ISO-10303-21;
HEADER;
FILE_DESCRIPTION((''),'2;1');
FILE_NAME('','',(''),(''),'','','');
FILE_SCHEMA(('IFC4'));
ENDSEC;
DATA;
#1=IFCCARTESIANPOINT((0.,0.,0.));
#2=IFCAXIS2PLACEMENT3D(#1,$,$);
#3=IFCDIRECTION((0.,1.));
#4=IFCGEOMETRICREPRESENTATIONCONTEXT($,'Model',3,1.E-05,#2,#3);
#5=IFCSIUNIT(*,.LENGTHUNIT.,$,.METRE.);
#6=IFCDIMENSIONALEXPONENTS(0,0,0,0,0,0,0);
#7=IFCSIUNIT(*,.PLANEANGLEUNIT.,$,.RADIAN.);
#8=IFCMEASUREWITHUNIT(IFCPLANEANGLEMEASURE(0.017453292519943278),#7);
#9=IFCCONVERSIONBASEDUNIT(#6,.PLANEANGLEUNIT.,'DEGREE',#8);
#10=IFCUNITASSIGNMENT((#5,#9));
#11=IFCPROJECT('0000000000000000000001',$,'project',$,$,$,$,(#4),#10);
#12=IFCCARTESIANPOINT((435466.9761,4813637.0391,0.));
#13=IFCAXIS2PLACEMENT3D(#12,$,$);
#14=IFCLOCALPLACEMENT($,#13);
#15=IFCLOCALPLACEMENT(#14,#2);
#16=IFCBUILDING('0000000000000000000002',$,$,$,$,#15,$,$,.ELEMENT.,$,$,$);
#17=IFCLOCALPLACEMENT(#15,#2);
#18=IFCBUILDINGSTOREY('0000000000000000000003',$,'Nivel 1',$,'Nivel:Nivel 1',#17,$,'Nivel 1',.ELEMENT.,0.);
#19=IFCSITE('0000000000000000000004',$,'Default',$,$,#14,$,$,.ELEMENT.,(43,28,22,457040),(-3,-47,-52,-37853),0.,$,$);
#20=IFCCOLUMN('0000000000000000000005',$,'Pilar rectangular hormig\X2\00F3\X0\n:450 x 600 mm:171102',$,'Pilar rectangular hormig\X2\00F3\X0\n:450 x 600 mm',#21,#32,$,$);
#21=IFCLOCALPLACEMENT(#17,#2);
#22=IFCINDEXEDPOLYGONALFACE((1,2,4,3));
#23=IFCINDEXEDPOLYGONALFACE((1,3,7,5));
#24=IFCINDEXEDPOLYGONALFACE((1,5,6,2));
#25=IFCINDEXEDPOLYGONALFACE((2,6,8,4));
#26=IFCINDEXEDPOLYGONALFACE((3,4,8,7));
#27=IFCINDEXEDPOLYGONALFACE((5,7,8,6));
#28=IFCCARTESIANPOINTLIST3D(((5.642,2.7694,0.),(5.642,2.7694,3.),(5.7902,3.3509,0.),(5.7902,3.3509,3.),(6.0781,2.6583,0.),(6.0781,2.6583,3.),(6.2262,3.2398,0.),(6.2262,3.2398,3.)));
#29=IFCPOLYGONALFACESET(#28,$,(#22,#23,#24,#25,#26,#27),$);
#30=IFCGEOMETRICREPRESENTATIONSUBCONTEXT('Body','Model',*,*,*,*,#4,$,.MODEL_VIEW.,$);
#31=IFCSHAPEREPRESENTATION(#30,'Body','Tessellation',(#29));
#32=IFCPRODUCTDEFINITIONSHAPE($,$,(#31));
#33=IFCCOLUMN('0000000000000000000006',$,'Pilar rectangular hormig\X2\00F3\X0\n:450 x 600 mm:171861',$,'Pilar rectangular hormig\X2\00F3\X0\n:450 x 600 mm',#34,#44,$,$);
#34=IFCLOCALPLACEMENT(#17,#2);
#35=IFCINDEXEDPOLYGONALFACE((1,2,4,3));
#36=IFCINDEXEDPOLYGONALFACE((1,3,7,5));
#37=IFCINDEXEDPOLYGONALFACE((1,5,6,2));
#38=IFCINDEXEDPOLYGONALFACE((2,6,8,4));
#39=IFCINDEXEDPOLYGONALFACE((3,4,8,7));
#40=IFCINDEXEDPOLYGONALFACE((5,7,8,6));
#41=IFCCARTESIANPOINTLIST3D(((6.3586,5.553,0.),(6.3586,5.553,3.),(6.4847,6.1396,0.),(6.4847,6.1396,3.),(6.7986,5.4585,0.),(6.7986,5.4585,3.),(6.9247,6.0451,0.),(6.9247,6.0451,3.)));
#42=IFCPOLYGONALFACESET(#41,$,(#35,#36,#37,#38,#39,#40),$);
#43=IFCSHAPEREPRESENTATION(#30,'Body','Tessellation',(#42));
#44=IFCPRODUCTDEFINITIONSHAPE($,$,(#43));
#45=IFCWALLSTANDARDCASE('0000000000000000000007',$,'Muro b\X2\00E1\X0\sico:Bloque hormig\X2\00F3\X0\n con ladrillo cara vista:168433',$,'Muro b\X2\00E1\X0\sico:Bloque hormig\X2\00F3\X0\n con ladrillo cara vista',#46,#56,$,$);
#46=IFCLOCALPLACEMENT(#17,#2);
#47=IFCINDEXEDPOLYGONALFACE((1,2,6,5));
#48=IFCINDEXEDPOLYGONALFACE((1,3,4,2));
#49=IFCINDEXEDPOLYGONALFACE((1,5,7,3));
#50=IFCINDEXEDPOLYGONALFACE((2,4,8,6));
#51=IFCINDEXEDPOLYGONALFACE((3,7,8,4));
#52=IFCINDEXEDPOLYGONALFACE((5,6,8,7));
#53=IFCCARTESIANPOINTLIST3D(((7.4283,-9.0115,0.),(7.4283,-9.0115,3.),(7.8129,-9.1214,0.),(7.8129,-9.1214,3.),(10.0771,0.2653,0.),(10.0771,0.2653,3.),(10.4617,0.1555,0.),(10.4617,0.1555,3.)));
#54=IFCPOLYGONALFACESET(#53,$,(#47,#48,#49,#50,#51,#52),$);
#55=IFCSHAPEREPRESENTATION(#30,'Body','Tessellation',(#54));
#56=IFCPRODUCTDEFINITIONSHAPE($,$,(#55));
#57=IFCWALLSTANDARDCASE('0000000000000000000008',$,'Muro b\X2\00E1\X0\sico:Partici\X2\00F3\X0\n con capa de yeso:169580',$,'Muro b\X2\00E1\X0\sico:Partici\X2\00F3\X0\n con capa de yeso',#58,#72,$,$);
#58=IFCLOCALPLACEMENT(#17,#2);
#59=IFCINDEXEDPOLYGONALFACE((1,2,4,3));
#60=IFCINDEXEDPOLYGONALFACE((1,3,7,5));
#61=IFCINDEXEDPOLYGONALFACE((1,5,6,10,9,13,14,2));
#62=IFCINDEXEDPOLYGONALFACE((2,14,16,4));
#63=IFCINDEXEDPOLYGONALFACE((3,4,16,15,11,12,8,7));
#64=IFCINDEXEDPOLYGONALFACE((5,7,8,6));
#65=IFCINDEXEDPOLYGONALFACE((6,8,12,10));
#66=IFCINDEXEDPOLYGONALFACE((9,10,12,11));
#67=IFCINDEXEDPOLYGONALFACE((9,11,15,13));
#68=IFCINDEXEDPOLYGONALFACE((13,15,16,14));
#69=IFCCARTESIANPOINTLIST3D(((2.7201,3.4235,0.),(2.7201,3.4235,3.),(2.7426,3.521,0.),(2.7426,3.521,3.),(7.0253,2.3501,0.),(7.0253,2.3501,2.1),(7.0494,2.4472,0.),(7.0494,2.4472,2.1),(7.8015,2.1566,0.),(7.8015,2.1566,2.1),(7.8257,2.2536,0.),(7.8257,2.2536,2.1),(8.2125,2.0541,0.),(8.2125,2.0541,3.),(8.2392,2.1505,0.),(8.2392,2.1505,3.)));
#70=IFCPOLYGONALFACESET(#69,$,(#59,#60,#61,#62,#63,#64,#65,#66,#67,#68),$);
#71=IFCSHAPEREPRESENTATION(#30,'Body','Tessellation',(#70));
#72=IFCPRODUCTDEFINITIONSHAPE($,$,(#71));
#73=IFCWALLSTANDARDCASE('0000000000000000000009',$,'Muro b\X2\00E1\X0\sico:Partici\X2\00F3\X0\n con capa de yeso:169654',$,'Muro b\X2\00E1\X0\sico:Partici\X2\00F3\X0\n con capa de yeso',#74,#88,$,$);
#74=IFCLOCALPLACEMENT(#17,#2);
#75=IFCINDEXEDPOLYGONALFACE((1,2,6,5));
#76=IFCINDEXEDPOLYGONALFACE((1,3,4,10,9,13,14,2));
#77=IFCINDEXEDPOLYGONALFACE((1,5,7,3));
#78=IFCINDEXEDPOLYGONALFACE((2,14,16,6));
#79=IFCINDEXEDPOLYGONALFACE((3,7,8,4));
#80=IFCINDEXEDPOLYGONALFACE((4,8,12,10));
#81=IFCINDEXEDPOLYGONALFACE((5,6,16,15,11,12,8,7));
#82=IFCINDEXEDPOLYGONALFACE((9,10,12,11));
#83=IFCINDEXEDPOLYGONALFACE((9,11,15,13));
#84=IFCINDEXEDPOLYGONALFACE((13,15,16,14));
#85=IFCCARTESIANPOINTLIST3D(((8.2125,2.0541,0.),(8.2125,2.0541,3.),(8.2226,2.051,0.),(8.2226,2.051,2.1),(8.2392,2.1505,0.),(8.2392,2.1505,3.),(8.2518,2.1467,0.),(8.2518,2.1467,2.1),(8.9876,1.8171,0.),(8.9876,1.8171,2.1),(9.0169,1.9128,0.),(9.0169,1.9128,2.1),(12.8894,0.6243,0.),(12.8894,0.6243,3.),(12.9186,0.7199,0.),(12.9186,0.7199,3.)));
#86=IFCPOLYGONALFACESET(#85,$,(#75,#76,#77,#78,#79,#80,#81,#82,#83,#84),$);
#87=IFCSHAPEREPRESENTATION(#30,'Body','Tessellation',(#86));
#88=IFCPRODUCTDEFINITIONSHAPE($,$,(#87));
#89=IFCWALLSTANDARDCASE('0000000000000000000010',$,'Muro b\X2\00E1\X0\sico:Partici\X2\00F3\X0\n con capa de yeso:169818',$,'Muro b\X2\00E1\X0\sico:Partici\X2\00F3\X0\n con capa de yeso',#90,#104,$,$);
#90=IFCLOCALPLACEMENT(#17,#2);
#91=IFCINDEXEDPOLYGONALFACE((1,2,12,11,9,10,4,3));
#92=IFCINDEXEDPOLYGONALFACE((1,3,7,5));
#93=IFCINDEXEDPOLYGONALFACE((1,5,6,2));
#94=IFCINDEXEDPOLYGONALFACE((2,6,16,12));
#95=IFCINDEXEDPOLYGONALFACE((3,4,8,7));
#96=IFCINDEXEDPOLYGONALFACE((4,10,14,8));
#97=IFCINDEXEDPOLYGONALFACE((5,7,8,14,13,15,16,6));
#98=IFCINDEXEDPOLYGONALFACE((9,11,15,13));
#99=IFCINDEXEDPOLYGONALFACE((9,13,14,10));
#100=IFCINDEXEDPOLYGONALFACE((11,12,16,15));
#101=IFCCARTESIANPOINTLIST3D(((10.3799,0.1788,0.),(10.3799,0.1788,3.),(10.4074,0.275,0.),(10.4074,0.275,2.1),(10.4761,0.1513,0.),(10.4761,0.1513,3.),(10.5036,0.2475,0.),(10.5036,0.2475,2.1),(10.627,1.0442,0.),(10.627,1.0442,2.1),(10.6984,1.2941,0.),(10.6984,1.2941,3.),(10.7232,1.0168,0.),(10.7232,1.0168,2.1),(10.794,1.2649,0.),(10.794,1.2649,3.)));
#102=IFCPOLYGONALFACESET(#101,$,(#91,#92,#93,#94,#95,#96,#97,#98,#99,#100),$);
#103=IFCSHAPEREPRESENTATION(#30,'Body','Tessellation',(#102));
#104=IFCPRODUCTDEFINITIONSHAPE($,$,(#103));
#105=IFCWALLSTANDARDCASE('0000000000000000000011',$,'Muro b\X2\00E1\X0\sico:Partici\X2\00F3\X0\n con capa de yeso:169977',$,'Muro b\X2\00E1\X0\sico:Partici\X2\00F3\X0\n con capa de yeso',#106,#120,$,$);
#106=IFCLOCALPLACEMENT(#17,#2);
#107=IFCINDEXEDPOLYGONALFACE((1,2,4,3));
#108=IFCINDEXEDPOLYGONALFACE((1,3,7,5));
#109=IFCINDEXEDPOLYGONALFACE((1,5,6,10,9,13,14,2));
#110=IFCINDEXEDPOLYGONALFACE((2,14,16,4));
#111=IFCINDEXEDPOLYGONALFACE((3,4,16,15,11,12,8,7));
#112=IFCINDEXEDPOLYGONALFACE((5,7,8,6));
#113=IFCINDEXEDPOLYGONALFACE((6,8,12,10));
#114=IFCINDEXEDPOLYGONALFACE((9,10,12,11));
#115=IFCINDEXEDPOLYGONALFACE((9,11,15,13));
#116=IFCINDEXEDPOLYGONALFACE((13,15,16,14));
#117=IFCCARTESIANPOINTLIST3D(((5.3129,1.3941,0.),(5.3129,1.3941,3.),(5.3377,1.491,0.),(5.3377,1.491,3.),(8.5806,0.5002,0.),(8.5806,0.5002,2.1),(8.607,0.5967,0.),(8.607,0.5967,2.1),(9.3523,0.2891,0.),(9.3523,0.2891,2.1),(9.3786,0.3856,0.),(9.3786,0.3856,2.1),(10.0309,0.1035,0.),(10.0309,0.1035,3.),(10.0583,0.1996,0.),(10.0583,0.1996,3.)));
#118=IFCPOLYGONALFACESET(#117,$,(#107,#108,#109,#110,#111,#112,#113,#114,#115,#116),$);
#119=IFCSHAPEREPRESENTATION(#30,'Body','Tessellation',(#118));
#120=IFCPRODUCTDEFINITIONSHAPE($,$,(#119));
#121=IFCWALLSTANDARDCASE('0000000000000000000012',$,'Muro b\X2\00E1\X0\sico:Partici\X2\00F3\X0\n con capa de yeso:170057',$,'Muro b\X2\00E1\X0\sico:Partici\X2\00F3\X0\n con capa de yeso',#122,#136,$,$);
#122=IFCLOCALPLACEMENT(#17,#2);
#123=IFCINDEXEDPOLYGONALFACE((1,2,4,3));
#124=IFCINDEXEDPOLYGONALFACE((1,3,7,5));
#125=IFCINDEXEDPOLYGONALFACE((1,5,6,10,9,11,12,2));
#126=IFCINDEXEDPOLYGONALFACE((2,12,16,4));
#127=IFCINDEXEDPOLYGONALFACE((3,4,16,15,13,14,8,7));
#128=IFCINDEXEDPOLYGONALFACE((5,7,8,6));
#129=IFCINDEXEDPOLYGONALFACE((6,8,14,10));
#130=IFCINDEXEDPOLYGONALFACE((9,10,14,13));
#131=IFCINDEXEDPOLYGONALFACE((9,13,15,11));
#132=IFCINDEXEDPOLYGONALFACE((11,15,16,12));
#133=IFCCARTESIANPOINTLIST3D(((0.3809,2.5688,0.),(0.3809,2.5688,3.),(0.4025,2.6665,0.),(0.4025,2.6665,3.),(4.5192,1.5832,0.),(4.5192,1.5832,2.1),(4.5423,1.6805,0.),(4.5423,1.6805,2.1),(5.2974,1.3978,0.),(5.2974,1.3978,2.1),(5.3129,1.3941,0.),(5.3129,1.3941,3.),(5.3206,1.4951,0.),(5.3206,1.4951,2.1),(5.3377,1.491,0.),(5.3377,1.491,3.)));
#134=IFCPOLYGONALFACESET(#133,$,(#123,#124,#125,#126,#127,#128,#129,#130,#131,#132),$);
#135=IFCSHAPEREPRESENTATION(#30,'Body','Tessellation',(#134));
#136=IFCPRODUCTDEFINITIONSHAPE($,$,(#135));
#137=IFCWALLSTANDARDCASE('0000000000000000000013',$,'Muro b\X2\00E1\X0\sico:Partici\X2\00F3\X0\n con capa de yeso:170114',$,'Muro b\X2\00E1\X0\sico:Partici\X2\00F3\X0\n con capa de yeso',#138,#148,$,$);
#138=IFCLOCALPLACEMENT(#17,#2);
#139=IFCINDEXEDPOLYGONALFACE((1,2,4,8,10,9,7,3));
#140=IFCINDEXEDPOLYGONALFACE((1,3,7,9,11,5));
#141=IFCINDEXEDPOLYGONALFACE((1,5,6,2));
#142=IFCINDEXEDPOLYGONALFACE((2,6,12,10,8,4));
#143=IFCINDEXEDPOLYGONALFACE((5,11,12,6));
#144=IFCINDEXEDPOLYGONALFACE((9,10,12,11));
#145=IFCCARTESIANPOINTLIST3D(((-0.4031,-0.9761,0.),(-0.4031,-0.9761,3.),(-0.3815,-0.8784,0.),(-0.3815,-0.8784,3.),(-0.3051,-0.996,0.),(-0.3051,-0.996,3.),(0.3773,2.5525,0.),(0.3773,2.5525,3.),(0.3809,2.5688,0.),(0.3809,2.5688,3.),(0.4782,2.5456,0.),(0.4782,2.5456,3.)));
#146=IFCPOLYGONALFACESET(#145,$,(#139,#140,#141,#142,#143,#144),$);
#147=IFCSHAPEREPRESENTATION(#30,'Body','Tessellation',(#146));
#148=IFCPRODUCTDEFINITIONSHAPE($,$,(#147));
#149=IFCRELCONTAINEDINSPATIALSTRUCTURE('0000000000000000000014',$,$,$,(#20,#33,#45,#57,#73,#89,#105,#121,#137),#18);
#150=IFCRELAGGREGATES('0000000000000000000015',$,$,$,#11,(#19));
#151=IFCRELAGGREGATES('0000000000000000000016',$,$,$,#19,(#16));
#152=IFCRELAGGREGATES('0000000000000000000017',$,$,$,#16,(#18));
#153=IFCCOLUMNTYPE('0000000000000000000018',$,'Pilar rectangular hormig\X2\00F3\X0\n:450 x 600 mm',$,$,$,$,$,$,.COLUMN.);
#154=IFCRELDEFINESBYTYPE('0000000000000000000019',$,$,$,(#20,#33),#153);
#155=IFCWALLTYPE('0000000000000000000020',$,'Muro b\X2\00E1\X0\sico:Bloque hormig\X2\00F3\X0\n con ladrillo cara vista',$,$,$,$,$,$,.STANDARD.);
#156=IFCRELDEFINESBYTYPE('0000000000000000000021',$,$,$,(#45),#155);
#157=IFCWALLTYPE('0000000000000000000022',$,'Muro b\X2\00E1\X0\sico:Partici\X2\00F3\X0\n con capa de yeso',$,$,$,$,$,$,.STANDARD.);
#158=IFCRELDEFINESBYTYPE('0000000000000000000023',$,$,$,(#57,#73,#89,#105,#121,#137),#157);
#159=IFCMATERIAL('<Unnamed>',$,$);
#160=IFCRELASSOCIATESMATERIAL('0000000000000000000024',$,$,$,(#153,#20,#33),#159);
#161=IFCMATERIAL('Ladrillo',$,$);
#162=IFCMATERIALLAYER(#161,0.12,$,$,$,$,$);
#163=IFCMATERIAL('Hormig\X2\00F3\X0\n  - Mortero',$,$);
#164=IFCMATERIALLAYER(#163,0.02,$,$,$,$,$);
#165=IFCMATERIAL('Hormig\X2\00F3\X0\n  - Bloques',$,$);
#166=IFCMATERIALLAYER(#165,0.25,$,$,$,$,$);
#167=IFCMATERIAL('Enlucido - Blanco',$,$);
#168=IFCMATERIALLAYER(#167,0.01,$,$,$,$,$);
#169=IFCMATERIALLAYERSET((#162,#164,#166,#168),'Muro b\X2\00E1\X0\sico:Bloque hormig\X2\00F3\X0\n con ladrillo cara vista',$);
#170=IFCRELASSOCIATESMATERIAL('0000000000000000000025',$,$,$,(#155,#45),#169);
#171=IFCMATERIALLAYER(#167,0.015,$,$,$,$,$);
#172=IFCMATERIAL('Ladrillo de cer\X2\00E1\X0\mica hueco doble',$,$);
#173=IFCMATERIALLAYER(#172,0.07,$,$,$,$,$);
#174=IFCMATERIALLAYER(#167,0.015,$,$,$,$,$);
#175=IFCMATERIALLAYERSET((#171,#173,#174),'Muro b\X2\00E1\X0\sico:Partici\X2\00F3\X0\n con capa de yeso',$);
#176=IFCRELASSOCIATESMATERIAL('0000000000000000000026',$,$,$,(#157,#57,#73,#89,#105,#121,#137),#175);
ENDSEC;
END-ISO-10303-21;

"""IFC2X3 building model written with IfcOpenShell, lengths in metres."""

from ifc_helpers import new_model, entity, si_unit, converted_unit, direction, frame, frame_2d, origin, origin_2d_with_axis, place, context, subcontext, project, spatial, polyline, rectangle, outline, extrude, source, transform, mapped, material, layer, layer_set, layer_usage, type_object, type_shapes, element, save


model = new_model("IFC2X3")

# Units and contexts
model_context = context("Model", 3, precision=1e-05, world=origin(), true_north=direction((0.0, 1.0)))
body_context = subcontext(model_context, "Body", "Model", "MODEL_VIEW")
ifc_project = project(units=[si_unit("LENGTHUNIT", "METRE"), converted_unit("PLANEANGLEUNIT", "DEGREE", entity("IfcPlaneAngleMeasure", 0.017453292519943278), si_unit("PLANEANGLEUNIT", "RADIAN"), dimensions=[0, 0, 0, 0, 0, 0, 0])], contexts=[model_context])

# Site, building, storey
site_placement = place(None, frame((435466.9761, 4813637.0391, 0.0)))
site = spatial("IfcSite", under=ifc_project, at=site_placement, Name="Default", CompositionType="ELEMENT", RefLatitude=(43, 28, 22, 457040), RefLongitude=(-3, -47, -52, -37853), RefElevation=0.0)
building_placement = place(site_placement, origin())
building = spatial("IfcBuilding", under=site, at=building_placement, CompositionType="ELEMENT")
storey_placement = place(building_placement, origin())
storey = spatial("IfcBuildingStorey", under=building, at=storey_placement, Name="Nivel 1", ObjectType="Nivel:Nivel 1", LongName="Nivel 1", CompositionType="ELEMENT", Elevation=0.0)

# Columns
ifc_material_1 = material(Name="<Unnamed>")
column_type = type_object("IfcColumnType", Name="Pilar rectangular hormigón:450 x 600 mm", PredefinedType="COLUMN", material=ifc_material_1)
shared_shape_1 = source(origin(), body_context, "Body", "SweptSolid", [
    extrude(rectangle(XDim=0.45, YDim=0.6, at=origin_2d_with_axis()), frame((0.0, 0.0, 0.0), z_axis=(0.0, 0.0, 1.0), x_axis=(-1.0, 0.0, 0.0)), (0.0, 0.0, 1.0), 3.0),
])
type_shapes(column_type, [shared_shape_1])
for number, where, z_axis, x_axis, name in (
    (1, (5.9341, 3.0046, 0.0), (0.0, 0.0, 1.0), (0.969039, -0.246908, 0.0), "Pilar rectangular hormigón:450 x 600 mm:171102"),
    (2, (6.6416, 5.799, 0.0), (0.0, 0.0, 1.0), (0.977667, -0.210159, 0.0), "Pilar rectangular hormigón:450 x 600 mm:171861"),
):
    element("IfcColumn", number, at=place(storey_placement, frame(where, z_axis=z_axis, x_axis=x_axis)), inside=storey, type_object=column_type, material=ifc_material_1, Name=name, ObjectType="Pilar rectangular hormigón:450 x 600 mm", context=body_context, shape_type="MappedRepresentation", body=[
        mapped(shared_shape_1, transform((0.0, 0.0, 0.0), scale=1.0)),
    ])

# Shared definitions
ifc_material_2 = material(Name="Enlucido - Blanco")

# Wall
ifc_material_3 = material(Name="Ladrillo")
ifc_layer_1 = layer(ifc_material_3, 0.12)
ifc_material_4 = material(Name="Hormigón  - Mortero")
ifc_layer_2 = layer(ifc_material_4, 0.02)
ifc_material_5 = material(Name="Hormigón  - Bloques")
ifc_layer_3 = layer(ifc_material_5, 0.25)
ifc_layer_4 = layer(ifc_material_2, 0.01)
ifc_layer_set_1 = layer_set([ifc_layer_1, ifc_layer_2, ifc_layer_3, ifc_layer_4], Name="Muro básico:Bloque hormigón con ladrillo cara vista")
wall_type_1 = type_object("IfcWallType", Name="Muro básico:Bloque hormigón con ladrillo cara vista", PredefinedType="STANDARD", material=ifc_layer_set_1)
ifc_layer_usage_1 = layer_usage(ifc_layer_set_1, "AXIS2", "NEGATIVE", 0.2)
wall_1_placement = place(storey_placement, frame((10.2694, 0.2104, 0.0), z_axis=(0.0, 0.0, 1.0), x_axis=(-0.274552, -0.961572, 0.0)))
element("IfcWallStandardCase", 3, at=wall_1_placement, inside=storey, type_object=wall_type_1, material=ifc_layer_usage_1, Name="Muro básico:Bloque hormigón con ladrillo cara vista:168433", ObjectType="Muro básico:Bloque hormigón con ladrillo cara vista", context=body_context, shape_type="SweptSolid", body=[
    extrude(rectangle(XDim=9.6476, YDim=0.4, at=frame_2d((4.8238, 0.0), x_axis=(-1.0, 0.0))), origin(), (0.0, 0.0, 1.0), 3.0),
])

# Walls, openings
ifc_layer_5 = layer(ifc_material_2, 0.015)
ifc_material_6 = material(Name="Ladrillo de cerámica hueco doble")
ifc_layer_6 = layer(ifc_material_6, 0.07)
ifc_layer_7 = layer(ifc_material_2, 0.015)
ifc_layer_set_2 = layer_set([ifc_layer_5, ifc_layer_6, ifc_layer_7], Name="Muro básico:Partición con capa de yeso")
ifc_layer_usage_2 = layer_usage(ifc_layer_set_2, "AXIS2", "NEGATIVE", 0.05)
wall_type_2 = type_object("IfcWallType", Name="Muro básico:Partición con capa de yeso", PredefinedType="STANDARD", material=ifc_layer_set_2)
wall_2_placement = place(storey_placement, frame((2.7305, 3.4725, 0.0), z_axis=(0.0, 0.0, 1.0), x_axis=(0.970296, -0.241922, 0.0)))
wall_2 = element("IfcWallStandardCase", 4, at=wall_2_placement, inside=storey, type_object=wall_type_2, material=ifc_layer_usage_2, Name="Muro básico:Partición con capa de yeso:169580", ObjectType="Muro básico:Partición con capa de yeso", context=body_context, shape_type="SweptSolid", body=[
    extrude(outline(polyline([(0.0018, -0.05), (5.6622, -0.05), (5.6648, 0.05), (5.4827, 0.05), (5.3826, 0.05), (0.4422, 0.05), (0.3422, 0.05), (0.0, 0.05), (0.0018, -0.05)])), origin(), (0.0, 0.0, 1.0), 3.0),
])
opening_1_placement = place(wall_2_placement, frame((4.4387, -0.05, 0.0)))
element("IfcOpeningElement", 5, at=opening_1_placement, cuts=wall_2, ObjectType="Opening", context=body_context, shape_type="SweptSolid", body=[
    extrude(rectangle(XDim=2.1, YDim=0.8, at=frame_2d((1.05, 0.4), x_axis=(1.0, 0.0))), frame((0.0, 0.0, 0.0), z_axis=(0.0, 1.0, 0.0), x_axis=(0.0, 0.0, 1.0)), (0.0, 0.0, 1.0), 0.1),
])
ifc_layer_usage_3 = layer_usage(ifc_layer_set_2, "AXIS2", "NEGATIVE", 0.05)
wall_3_placement = place(storey_placement, frame((8.2246, 2.1027, 0.0), z_axis=(0.0, 0.0, 1.0), x_axis=(0.956305, -0.292372, 0.0)))
wall_3 = element("IfcWallStandardCase", 6, at=wall_3_placement, inside=storey, type_object=wall_type_2, material=ifc_layer_usage_3, Name="Muro básico:Partición con capa de yeso:169654", ObjectType="Muro básico:Partición con capa de yeso", context=body_context, shape_type="SweptSolid", body=[
    extrude(outline(polyline([(0.0026, -0.05), (2.6022, -0.05), (2.7022, -0.05), (4.8932, -0.05), (4.8932, 0.05), (0.0, 0.05), (0.0026, -0.05)])), origin(), (0.0, 0.0, 1.0), 3.0),
])
opening_2_placement = place(wall_3_placement, frame((0.0132, -0.05, 0.0)))
element("IfcOpeningElement", 7, at=opening_2_placement, cuts=wall_3, ObjectType="Opening", context=body_context, shape_type="SweptSolid", body=[
    extrude(rectangle(XDim=2.1, YDim=0.8, at=frame_2d((1.05, 0.4), x_axis=(1.0, 0.0))), frame((0.0, 0.0, 0.0), z_axis=(0.0, 1.0, 0.0), x_axis=(0.0, 0.0, 1.0)), (0.0, 0.0, 1.0), 0.1),
])
ifc_layer_usage_4 = layer_usage(ifc_layer_set_2, "AXIS2", "NEGATIVE", 0.05)
wall_4_placement = place(storey_placement, frame((10.7465, 1.2804, 0.0), z_axis=(0.0, 0.0, 1.0), x_axis=(-0.274552, -0.961572, 0.0)))
wall_4 = element("IfcWallStandardCase", 8, at=wall_4_placement, inside=storey, type_object=wall_type_2, material=ifc_layer_usage_4, Name="Muro básico:Partición con capa de yeso:169818", ObjectType="Muro básico:Partición con capa de yeso", context=body_context, shape_type="SweptSolid", body=[
    extrude(outline(polyline([(0.0, -0.05), (1.1599, -0.05), (1.1599, 0.035), (1.1599, 0.05), (0.0019, 0.05), (0.0, -0.05)])), origin(), (0.0, 0.0, 1.0), 3.0),
])
opening_3_placement = place(wall_4_placement, frame((0.2599, -0.05, 0.0)))
element("IfcOpeningElement", 9, at=opening_3_placement, cuts=wall_4, ObjectType="Opening", context=body_context, shape_type="SweptSolid", body=[
    extrude(rectangle(XDim=2.1, YDim=0.8, at=frame_2d((1.05, 0.4), x_axis=(1.0, 0.0))), frame((0.0, 0.0, 0.0), z_axis=(0.0, 1.0, 0.0), x_axis=(0.0, 0.0, 1.0)), (0.0, 0.0, 1.0), 0.1),
])
ifc_layer_usage_5 = layer_usage(ifc_layer_set_2, "AXIS2", "POSITIVE", -0.05)
wall_5_placement = place(storey_placement, frame((10.0451, 0.1514, 0.0), z_axis=(0.0, 0.0, 1.0), x_axis=(-0.964559, 0.263866, 0.0)))
wall_5 = element("IfcWallStandardCase", 10, at=wall_5_placement, inside=storey, type_object=wall_type_2, material=ifc_layer_usage_5, Name="Muro básico:Partición con capa de yeso:169977", ObjectType="Muro básico:Partición con capa de yeso", context=body_context, shape_type="SweptSolid", body=[
    extrude(outline(polyline([(0.0, -0.05), (4.8941, -0.05), (4.8925, 0.05), (0.0011, 0.05), (0.0, -0.05)])), origin(), (0.0, 0.0, 1.0), 3.0),
])
opening_4_placement = place(wall_5_placement, frame((0.7046, -0.05, 0.0)))
element("IfcOpeningElement", 11, at=opening_4_placement, cuts=wall_5, ObjectType="Opening", context=body_context, shape_type="SweptSolid", body=[
    extrude(rectangle(XDim=2.1, YDim=0.8, at=frame_2d((1.05, 0.4), x_axis=(1.0, 0.0))), frame((0.0, 0.0, 0.0), z_axis=(0.0, 1.0, 0.0), x_axis=(0.0, 0.0, 1.0)), (0.0, 0.0, 1.0), 0.1),
])
ifc_layer_usage_6 = layer_usage(ifc_layer_set_2, "AXIS2", "POSITIVE", -0.05)
wall_6_placement = place(storey_placement, frame((5.3261, 1.4424, 0.0), z_axis=(0.0, 0.0, 1.0), x_axis=(-0.972789, 0.231693, 0.0)))
wall_6 = element("IfcWallStandardCase", 12, at=wall_6_placement, inside=storey, type_object=wall_type_2, material=ifc_layer_usage_6, Name="Muro básico:Partición con capa de yeso:170057", ObjectType="Muro básico:Partición con capa de yeso", context=body_context, shape_type="SweptSolid", body=[
    extrude(outline(polyline([(0.0, -0.05), (5.0732, -0.05), (5.0729, -0.0333), (5.0716, 0.05), (4.9716, 0.05), (0.0017, 0.05), (0.0, -0.05)])), origin(), (0.0, 0.0, 1.0), 3.0),
])
opening_5_placement = place(wall_6_placement, frame((0.0176, -0.05, 0.0)))
element("IfcOpeningElement", 13, at=opening_5_placement, cuts=wall_6, ObjectType="Opening", context=body_context, shape_type="SweptSolid", body=[
    extrude(rectangle(XDim=2.1, YDim=0.8, at=frame_2d((1.05, 0.4), x_axis=(1.0, 0.0))), frame((0.0, 0.0, 0.0), z_axis=(0.0, 1.0, 0.0), x_axis=(0.0, 0.0, 1.0)), (0.0, 0.0, 1.0), 0.1),
])

# Wall
ifc_layer_usage_7 = layer_usage(ifc_layer_set_2, "AXIS2", "POSITIVE", -0.05)
wall_7_placement = place(storey_placement, frame((0.4297, 2.558, 0.0), z_axis=(0.0, 0.0, 1.0), x_axis=(-0.215934, -0.976408, 0.0)))
element("IfcWallStandardCase", 14, at=wall_7_placement, inside=storey, type_object=wall_type_2, material=ifc_layer_usage_7, Name="Muro básico:Partición con capa de yeso:170114", ObjectType="Muro básico:Partición con capa de yeso", context=body_context, shape_type="SweptSolid", body=[
    extrude(outline(polyline([(3.6305, -0.05), (3.6289, 0.05), (0.0016, 0.05), (0.0, -0.05), (0.0167, -0.05), (3.5305, -0.05), (3.6305, -0.05)])), origin(), (0.0, 0.0, 1.0), 3.0),
])

save(model, "model.ifc")
